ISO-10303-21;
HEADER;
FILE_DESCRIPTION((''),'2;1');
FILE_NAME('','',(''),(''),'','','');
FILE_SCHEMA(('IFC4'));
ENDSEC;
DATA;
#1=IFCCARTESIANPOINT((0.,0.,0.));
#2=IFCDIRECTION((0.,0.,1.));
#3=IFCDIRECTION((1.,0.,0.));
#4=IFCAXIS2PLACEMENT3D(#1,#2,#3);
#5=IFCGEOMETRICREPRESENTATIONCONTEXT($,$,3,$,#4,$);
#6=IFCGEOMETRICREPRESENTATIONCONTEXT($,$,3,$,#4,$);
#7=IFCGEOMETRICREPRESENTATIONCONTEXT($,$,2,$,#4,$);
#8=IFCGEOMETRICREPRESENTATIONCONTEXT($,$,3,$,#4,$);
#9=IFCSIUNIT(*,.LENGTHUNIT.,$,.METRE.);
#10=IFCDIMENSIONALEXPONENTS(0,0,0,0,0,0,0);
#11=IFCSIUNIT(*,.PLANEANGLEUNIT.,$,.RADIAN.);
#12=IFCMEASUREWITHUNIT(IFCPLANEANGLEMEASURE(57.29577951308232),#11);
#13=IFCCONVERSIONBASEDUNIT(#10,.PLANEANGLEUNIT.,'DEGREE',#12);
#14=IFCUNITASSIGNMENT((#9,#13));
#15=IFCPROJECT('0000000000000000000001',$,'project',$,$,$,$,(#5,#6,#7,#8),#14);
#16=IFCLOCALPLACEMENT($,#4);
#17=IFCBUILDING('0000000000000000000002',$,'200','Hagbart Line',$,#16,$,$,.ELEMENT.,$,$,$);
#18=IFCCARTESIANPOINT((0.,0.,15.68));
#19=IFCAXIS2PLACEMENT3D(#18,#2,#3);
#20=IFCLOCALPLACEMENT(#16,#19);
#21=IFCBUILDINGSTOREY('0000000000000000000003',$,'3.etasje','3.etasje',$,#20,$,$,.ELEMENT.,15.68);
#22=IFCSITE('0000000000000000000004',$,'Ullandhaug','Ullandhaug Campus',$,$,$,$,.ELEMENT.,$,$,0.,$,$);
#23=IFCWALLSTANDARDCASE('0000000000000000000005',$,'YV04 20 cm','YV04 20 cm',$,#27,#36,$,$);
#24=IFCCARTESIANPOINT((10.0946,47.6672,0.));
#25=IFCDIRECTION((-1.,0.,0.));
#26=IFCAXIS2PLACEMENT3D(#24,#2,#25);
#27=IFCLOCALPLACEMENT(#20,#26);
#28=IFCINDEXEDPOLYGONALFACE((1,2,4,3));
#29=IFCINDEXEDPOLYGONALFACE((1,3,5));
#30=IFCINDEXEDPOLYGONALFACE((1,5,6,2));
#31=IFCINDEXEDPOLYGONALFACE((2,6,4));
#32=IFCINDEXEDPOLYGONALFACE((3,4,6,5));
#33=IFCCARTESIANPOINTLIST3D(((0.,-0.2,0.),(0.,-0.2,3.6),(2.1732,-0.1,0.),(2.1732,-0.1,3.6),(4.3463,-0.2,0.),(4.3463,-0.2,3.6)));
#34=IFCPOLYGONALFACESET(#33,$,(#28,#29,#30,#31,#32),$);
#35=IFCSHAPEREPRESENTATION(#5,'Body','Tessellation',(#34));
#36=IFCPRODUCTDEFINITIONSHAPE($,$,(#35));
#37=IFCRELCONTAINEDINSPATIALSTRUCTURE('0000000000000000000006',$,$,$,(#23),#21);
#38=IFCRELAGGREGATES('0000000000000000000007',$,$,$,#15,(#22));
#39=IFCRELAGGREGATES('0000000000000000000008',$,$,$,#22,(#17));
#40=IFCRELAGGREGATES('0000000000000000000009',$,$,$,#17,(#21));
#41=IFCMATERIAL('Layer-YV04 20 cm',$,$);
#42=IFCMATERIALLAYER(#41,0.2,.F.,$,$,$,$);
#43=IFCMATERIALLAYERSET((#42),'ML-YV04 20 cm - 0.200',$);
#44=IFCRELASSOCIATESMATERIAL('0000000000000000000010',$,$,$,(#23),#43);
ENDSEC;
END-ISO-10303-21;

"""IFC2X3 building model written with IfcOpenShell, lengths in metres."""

from ifc_helpers import new_model, entity, si_unit, converted_unit, frame, origin_with_axes, place, context, project, spatial, polyline, outline, extrude, material, layer, layer_set, layer_usage, element, save


model = new_model("IFC2X3")

# Units and contexts
context_of_model_1 = context(None, 3, world=origin_with_axes())
context_of_model_2 = context(None, 3, world=origin_with_axes())
context_of_model_3 = context(None, 2, world=origin_with_axes())
context_of_model_4 = context(None, 3, world=origin_with_axes())
ifc_project = project(units=[si_unit("LENGTHUNIT", "METRE"), converted_unit("PLANEANGLEUNIT", "DEGREE", entity("IfcPlaneAngleMeasure", 57.29577951308232), si_unit("PLANEANGLEUNIT", "RADIAN"), dimensions=[0, 0, 0, 0, 0, 0, 0])], contexts=[context_of_model_1, context_of_model_2, context_of_model_3, context_of_model_4])

# Site, building, storey
site = spatial("IfcSite", under=ifc_project, Name="Ullandhaug", Description="Ullandhaug Campus", CompositionType="ELEMENT", RefElevation=0.0)
building_placement = place(None, origin_with_axes())
building = spatial("IfcBuilding", under=site, at=building_placement, Name="200", Description="Hagbart Line", CompositionType="ELEMENT")
storey_placement = place(building_placement, frame((0.0, 0.0, 15.68), z_axis=(0.0, 0.0, 1.0), x_axis=(1.0, 0.0, 0.0)))
storey = spatial("IfcBuildingStorey", under=building, at=storey_placement, Name="3.etasje", Description="3.etasje", CompositionType="ELEMENT", Elevation=15.68)

# Wall
ifc_material_1 = material(Name="Layer-YV04 20 cm")
ifc_layer_1 = layer(ifc_material_1, 0.2, ventilated=False)
ifc_layer_set_1 = layer_set([ifc_layer_1], Name="ML-YV04 20 cm - 0.200")
ifc_layer_usage_1 = layer_usage(ifc_layer_set_1, "AXIS2", "POSITIVE", 0.0)
wall_1_placement = place(storey_placement, frame((10.0946, 47.6672, 0.0), z_axis=(0.0, 0.0, 1.0), x_axis=(-1.0, 0.0, 0.0)))
element("IfcWallStandardCase", 1, at=wall_1_placement, inside=storey, material=ifc_layer_usage_1, Name="YV04 20 cm", Description="YV04 20 cm", context=context_of_model_1, shape_type="SweptSolid", body=[
    extrude(outline(polyline([(0.0, 0.0), (4.3463, 0.0), (0.0, 0.2), (4.3463, 0.2), (0.0, 0.0)])), frame((0.0, 0.0, 0.0), z_axis=(0.0, 0.0, -1.0), x_axis=(1.0, 0.0, 0.0)), (0.0, 0.0, -1.0), 3.6),
])

save(model, "model.ifc")
